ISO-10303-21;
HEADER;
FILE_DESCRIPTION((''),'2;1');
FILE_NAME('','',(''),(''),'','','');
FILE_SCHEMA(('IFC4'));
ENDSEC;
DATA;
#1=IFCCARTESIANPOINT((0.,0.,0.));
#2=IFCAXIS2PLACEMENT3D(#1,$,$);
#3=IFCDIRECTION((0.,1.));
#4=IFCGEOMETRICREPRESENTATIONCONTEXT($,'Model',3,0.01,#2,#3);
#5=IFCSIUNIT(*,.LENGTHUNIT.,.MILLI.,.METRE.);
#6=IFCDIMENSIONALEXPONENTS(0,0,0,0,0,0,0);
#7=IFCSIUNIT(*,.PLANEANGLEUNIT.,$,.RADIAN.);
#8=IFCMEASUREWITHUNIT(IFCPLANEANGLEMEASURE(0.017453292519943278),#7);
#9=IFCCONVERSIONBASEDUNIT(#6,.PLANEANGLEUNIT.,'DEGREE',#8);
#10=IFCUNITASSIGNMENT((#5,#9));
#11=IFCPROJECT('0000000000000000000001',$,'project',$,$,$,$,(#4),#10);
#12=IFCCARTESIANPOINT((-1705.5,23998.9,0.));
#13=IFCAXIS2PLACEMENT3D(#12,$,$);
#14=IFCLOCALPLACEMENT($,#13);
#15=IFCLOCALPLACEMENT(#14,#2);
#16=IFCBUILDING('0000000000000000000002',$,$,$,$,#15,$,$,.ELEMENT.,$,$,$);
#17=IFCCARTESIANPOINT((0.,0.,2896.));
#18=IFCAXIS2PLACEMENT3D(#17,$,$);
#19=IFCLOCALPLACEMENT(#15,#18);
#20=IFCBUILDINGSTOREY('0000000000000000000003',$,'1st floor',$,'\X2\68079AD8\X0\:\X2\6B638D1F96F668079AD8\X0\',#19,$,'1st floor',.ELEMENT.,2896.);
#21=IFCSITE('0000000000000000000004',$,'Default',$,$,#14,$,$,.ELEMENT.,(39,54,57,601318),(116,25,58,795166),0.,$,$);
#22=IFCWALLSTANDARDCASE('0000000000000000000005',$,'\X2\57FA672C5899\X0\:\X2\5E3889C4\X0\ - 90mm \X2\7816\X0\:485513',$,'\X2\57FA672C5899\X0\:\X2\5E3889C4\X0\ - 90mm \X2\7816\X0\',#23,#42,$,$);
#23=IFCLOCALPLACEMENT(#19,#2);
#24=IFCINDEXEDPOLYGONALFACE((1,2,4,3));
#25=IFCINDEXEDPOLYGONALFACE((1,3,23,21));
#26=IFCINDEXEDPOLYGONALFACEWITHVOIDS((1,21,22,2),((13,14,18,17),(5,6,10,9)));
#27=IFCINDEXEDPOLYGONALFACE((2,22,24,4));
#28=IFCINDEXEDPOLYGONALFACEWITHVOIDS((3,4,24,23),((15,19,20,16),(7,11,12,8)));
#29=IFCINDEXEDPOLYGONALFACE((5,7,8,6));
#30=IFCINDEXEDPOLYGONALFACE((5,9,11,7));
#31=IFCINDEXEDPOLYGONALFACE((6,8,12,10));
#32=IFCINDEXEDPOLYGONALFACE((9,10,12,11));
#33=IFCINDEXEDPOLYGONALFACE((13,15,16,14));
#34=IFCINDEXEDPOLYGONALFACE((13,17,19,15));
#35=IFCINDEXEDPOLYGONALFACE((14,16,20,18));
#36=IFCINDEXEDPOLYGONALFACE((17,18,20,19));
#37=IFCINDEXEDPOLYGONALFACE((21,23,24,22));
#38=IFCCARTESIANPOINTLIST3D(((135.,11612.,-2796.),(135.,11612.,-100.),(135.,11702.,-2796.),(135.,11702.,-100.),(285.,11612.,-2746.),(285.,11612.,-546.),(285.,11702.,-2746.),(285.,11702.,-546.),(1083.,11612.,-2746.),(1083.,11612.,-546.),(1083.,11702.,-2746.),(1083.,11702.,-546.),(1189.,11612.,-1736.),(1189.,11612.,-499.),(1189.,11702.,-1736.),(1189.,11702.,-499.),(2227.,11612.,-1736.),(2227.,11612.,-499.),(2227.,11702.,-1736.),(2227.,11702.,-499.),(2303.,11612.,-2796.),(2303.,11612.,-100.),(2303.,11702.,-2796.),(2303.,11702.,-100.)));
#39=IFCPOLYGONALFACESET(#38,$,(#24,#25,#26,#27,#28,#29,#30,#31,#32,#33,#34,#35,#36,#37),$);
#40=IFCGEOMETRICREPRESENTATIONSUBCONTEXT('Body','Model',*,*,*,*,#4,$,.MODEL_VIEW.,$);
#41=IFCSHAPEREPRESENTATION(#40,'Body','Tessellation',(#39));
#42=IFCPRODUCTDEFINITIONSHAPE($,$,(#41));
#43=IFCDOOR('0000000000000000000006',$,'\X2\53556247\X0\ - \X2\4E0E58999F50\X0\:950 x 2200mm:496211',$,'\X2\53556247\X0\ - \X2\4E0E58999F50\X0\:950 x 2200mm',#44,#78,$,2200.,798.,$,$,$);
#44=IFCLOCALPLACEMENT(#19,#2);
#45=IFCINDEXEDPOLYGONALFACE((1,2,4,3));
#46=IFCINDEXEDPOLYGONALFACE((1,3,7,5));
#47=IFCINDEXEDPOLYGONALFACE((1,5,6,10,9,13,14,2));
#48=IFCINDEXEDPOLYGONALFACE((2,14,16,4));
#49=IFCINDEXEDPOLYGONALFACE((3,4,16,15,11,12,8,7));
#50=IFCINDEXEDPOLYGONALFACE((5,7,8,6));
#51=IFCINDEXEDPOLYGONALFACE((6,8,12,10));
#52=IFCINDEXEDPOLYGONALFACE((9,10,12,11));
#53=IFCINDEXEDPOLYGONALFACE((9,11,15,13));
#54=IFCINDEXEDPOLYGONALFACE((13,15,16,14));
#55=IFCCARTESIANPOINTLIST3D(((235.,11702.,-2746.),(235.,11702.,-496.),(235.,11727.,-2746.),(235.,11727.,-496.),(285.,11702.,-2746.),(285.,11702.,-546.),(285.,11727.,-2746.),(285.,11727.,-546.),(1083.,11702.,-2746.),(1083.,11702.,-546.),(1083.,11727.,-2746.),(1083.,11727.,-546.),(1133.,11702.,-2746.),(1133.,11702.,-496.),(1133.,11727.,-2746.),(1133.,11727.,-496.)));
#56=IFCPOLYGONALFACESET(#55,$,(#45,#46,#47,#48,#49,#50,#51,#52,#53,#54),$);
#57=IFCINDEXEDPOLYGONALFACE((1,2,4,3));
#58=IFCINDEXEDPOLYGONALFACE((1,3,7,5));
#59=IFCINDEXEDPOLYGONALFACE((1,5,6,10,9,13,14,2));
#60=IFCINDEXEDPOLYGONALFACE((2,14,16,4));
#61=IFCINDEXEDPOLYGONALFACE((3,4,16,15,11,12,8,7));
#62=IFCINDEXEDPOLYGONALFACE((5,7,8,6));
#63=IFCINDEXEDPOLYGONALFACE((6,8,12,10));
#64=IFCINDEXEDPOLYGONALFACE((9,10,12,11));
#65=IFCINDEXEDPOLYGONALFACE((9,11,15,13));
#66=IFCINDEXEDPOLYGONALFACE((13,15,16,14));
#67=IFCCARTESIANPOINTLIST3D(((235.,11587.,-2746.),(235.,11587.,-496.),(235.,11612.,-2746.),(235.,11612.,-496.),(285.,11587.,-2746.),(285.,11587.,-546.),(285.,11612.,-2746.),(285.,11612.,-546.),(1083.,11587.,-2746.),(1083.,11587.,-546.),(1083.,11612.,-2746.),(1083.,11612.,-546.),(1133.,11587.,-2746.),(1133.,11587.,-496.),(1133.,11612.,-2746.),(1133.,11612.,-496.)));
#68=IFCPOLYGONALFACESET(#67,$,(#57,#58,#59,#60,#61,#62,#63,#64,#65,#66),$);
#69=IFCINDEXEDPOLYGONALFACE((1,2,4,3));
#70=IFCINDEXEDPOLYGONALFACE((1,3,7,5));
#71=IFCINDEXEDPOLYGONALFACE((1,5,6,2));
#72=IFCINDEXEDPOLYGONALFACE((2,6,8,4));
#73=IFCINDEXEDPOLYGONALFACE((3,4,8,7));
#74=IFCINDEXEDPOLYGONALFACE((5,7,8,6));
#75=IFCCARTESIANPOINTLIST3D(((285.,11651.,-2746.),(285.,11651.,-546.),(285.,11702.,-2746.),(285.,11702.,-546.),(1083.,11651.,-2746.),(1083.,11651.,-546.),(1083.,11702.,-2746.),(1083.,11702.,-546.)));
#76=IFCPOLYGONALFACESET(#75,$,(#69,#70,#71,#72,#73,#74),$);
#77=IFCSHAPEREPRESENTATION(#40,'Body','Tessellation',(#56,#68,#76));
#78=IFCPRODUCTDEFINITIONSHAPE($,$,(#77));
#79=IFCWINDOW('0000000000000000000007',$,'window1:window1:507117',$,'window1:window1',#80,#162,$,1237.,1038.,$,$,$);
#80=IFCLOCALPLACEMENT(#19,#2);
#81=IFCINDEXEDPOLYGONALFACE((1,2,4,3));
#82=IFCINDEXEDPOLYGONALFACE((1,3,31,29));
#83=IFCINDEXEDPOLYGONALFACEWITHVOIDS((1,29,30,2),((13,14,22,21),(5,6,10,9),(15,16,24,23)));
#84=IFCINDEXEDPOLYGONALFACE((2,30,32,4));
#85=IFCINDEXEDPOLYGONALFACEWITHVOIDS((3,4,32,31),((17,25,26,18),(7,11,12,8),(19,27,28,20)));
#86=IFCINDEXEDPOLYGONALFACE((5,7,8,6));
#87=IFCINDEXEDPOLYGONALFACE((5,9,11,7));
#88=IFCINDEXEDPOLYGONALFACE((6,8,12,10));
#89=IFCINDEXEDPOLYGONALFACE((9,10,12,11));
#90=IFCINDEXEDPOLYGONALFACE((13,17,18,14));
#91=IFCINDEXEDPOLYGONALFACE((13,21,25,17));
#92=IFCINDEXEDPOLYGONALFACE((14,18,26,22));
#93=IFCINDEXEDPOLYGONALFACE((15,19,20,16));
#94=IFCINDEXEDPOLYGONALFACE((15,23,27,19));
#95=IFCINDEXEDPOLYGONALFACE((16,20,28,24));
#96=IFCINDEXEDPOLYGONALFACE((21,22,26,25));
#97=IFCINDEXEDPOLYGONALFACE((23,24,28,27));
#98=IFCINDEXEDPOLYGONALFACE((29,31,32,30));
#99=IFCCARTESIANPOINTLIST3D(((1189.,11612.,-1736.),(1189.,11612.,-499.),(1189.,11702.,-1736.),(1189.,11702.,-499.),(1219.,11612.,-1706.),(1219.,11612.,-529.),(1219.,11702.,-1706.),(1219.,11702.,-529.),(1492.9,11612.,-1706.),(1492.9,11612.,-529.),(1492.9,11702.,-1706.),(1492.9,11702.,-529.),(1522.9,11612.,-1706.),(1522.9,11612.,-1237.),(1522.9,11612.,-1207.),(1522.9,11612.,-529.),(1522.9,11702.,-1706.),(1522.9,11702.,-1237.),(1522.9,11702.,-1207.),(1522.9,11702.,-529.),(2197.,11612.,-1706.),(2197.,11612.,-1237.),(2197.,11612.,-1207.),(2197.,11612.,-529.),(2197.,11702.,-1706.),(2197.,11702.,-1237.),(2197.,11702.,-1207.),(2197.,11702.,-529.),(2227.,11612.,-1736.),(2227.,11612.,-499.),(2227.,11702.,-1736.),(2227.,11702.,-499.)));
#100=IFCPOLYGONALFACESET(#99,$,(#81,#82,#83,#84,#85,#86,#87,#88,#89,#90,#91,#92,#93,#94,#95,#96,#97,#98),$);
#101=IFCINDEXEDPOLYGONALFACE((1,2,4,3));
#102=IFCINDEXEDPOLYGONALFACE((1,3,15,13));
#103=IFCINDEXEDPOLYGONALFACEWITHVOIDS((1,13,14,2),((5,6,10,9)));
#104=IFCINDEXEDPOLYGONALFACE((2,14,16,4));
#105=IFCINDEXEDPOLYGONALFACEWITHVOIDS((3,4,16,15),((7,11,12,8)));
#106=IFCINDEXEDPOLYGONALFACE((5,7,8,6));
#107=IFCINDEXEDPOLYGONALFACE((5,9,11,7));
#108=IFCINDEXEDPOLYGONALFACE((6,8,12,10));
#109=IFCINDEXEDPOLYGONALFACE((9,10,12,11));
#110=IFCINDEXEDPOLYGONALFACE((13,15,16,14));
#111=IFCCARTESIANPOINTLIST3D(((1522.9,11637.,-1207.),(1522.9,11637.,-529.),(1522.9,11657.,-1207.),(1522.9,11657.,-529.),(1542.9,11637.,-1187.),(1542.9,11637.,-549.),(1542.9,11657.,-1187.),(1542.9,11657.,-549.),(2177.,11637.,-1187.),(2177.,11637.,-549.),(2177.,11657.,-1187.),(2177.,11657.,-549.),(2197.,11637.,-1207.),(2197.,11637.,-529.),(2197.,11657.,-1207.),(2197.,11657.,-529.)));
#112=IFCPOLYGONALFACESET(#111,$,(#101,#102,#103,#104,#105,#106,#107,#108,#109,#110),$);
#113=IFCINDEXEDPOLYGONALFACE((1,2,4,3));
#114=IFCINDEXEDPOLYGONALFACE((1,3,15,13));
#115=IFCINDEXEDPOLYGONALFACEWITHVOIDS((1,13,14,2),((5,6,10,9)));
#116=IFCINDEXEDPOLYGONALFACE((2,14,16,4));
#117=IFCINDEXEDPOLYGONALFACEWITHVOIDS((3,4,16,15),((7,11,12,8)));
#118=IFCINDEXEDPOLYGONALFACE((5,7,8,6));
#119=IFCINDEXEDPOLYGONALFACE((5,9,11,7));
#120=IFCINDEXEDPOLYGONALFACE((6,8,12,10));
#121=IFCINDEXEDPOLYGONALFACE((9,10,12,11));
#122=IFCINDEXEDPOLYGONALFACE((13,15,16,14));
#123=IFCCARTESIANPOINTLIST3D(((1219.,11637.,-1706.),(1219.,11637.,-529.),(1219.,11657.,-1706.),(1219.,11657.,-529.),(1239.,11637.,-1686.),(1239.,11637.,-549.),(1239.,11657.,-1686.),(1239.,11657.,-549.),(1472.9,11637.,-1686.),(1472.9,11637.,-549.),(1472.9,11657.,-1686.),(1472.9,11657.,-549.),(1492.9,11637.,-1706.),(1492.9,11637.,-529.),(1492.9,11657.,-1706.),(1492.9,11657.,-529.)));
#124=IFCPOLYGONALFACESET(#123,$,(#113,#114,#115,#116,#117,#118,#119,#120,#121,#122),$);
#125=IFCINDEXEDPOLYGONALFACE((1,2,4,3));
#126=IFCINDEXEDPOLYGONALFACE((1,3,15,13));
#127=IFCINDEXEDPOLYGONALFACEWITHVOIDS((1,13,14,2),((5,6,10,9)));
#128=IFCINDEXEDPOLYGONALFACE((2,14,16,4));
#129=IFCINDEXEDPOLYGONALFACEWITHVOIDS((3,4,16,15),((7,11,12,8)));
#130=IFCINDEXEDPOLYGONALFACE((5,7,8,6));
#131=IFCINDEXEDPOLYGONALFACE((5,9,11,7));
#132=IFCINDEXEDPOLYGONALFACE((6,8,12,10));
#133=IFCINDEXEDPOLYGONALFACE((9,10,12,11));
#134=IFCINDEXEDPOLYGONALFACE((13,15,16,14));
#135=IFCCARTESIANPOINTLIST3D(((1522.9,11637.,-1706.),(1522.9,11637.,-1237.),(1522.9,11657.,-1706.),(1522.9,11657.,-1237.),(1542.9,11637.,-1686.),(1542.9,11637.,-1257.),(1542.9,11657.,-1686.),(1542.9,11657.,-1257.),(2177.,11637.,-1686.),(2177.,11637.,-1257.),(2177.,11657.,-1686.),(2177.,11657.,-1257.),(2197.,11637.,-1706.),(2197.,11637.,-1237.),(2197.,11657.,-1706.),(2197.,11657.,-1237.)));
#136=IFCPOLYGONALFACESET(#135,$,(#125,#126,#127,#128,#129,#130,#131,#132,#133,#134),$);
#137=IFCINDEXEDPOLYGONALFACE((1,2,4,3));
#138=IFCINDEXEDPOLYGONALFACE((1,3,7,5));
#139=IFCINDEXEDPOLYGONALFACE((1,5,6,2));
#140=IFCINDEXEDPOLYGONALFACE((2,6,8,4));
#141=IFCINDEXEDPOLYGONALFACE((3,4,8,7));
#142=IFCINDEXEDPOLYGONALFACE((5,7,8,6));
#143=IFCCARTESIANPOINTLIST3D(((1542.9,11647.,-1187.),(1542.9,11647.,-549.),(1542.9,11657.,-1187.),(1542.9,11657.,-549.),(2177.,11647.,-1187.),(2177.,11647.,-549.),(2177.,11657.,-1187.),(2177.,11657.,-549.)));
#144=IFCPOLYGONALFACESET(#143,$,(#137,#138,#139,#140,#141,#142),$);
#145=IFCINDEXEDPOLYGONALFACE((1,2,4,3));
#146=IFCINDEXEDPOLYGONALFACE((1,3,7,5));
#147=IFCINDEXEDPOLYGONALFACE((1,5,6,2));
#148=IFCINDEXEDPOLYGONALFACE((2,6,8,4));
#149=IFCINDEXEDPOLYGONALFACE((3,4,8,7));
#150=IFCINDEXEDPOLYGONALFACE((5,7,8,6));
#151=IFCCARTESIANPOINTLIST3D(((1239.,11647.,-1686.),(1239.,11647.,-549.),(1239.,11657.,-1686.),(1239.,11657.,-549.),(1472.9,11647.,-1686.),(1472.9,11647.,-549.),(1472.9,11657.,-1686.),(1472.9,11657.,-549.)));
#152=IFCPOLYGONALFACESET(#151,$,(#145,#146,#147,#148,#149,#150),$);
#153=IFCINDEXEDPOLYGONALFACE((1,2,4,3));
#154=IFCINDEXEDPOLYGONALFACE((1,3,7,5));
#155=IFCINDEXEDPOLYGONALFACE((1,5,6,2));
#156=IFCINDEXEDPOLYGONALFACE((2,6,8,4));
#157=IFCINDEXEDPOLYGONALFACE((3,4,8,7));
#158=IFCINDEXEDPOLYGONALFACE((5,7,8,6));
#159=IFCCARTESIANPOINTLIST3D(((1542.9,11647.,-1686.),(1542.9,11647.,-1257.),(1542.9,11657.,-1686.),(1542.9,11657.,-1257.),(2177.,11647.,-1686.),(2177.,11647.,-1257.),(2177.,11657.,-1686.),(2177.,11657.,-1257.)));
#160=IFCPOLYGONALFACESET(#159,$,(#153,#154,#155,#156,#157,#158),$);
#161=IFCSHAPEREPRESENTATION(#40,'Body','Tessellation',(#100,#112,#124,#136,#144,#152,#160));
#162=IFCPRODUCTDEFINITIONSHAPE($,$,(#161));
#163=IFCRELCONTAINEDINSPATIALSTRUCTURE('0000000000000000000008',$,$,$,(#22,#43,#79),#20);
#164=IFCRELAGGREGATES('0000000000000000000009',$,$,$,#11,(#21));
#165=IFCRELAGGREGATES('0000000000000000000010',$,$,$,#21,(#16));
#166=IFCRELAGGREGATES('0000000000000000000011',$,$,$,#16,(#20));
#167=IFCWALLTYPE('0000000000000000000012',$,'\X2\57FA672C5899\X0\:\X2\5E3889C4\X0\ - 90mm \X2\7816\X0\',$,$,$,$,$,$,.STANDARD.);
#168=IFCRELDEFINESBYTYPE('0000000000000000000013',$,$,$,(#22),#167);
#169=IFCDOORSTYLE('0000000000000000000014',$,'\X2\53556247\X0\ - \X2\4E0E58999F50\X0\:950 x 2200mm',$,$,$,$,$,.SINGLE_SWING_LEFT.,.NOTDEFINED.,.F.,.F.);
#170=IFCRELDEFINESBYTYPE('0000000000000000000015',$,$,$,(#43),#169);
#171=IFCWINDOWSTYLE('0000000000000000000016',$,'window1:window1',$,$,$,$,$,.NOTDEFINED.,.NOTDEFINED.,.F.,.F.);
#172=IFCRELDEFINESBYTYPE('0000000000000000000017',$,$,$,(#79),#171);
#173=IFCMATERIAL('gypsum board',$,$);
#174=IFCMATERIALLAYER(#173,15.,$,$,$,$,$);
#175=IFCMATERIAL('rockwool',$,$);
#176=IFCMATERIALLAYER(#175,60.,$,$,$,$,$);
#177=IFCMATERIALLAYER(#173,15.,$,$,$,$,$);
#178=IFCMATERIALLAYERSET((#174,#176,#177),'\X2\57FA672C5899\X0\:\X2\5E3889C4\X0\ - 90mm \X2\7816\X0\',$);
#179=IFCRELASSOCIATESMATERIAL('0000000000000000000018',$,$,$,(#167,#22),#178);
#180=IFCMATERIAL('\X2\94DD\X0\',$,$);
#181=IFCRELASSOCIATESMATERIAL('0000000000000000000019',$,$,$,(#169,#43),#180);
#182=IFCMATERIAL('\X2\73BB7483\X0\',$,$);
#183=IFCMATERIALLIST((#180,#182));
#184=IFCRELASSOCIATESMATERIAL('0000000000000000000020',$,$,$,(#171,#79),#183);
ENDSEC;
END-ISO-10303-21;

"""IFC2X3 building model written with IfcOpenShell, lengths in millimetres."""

from ifc_helpers import new_model, entity, si_unit, converted_unit, direction, frame, frame_2d, origin, origin_2d_with_axis, place, context, subcontext, project, spatial, polyline, rectangle, outline, extrude, source, transform, mapped, material, material_list, layer, layer_set, layer_usage, type_object, type_shapes, element, fill, save


model = new_model("IFC2X3")

# Units and contexts
model_context = context("Model", 3, precision=0.01, world=origin(), true_north=direction((0.0, 1.0)))
body_context = subcontext(model_context, "Body", "Model", "MODEL_VIEW")
ifc_project = project(units=[si_unit("LENGTHUNIT", "METRE", prefix="MILLI"), converted_unit("PLANEANGLEUNIT", "DEGREE", entity("IfcPlaneAngleMeasure", 0.017453292519943278), si_unit("PLANEANGLEUNIT", "RADIAN"), dimensions=[0, 0, 0, 0, 0, 0, 0])], contexts=[model_context])

# Site, building, storey
site_placement = place(None, frame((-1705.5, 23998.9, 0.0)))
site = spatial("IfcSite", under=ifc_project, at=site_placement, Name="Default", CompositionType="ELEMENT", RefLatitude=(39, 54, 57, 601318), RefLongitude=(116, 25, 58, 795166), RefElevation=0.0)
building_placement = place(site_placement, origin())
building = spatial("IfcBuilding", under=site, at=building_placement, CompositionType="ELEMENT")
storey_placement = place(building_placement, frame((0.0, 0.0, 2896.0)))
storey = spatial("IfcBuildingStorey", under=building, at=storey_placement, Name="1st floor", ObjectType="标高:正负零标高", LongName="1st floor", CompositionType="ELEMENT", Elevation=2896.0)

# Wall, openings, door, window
ifc_material_1 = material(Name="gypsum board")
ifc_layer_1 = layer(ifc_material_1, 15.0)
ifc_material_2 = material(Name="rockwool")
ifc_layer_2 = layer(ifc_material_2, 60.0)
ifc_layer_3 = layer(ifc_material_1, 15.0)
ifc_layer_set = layer_set([ifc_layer_1, ifc_layer_2, ifc_layer_3], Name="基本墙:常规 - 90mm 砖")
ifc_layer_usage_1 = layer_usage(ifc_layer_set, "AXIS2", "NEGATIVE", 45.0)
wall_type = type_object("IfcWallType", Name="基本墙:常规 - 90mm 砖", PredefinedType="STANDARD", material=ifc_layer_set)
wall_1_placement = place(storey_placement, frame((2303.0, 11657.0, -2796.0), z_axis=(0.0, 0.0, 1.0), x_axis=(-1.0, 0.0, 0.0)))
wall_1 = element("IfcWallStandardCase", 1, at=wall_1_placement, inside=storey, type_object=wall_type, material=ifc_layer_usage_1, Name="基本墙:常规 - 90mm 砖:485513", ObjectType="基本墙:常规 - 90mm 砖", context=body_context, shape_type="SweptSolid", body=[
    extrude(rectangle(XDim=2168.0, YDim=90.0, at=frame_2d((1084.0, 0.0), x_axis=(-1.0, 0.0))), origin(), (0.0, 0.0, 1.0), 2696.0),
])
opening_1_placement = place(wall_1_placement, frame((2018.0, 45.0, 50.0)))
opening_1 = element("IfcOpeningElement", 2, at=opening_1_placement, cuts=wall_1, ObjectType="Opening", context=body_context, shape_type="SweptSolid", body=[
    extrude(rectangle(XDim=798.0, YDim=2200.0, at=frame_2d((1100.0, 399.0), x_axis=(0.0, -1.0))), frame((0.0, 0.0, 0.0), z_axis=(0.0, -1.0, 0.0), x_axis=(0.0, 0.0, 1.0)), (0.0, 0.0, 1.0), 90.0),
])
opening_2_placement = place(wall_1_placement, frame((1114.0, 45.0, 1060.0)))
opening_2 = element("IfcOpeningElement", 3, at=opening_2_placement, cuts=wall_1, ObjectType="Opening", context=body_context, shape_type="SweptSolid", body=[
    extrude(rectangle(XDim=1237.0, YDim=1038.0, at=frame_2d((618.5, 519.0), x_axis=(1.0, 0.0))), frame((0.0, 0.0, 0.0), z_axis=(0.0, -1.0, 0.0), x_axis=(0.0, 0.0, 1.0)), (0.0, 0.0, 1.0), 90.0),
])
ifc_material_3 = material(Name="铝")
door_style = type_object("IfcDoorStyle", Name="单扇 - 与墙齐:950 x 2200mm", ConstructionType="NOTDEFINED", OperationType="SINGLE_SWING_LEFT", ParameterTakesPrecedence=False, Sizeable=False, material=ifc_material_3)
shared_shape_1 = source(origin(), body_context, "Body", "SweptSolid", [
    extrude(outline(polyline([(-449.0, -1137.5), (449.0, -1137.5), (449.0, 1112.5), (399.0, 1112.5), (399.0, -1087.5), (-399.0, -1087.5), (-399.0, 1112.5), (-449.0, 1112.5), (-449.0, -1137.5)])), frame((399.0, 115.0, 1112.5), z_axis=(0.0, -1.0, 0.0), x_axis=(-1.0, 0.0, 0.0)), (0.0, 0.0, 1.0), 25.0),
    extrude(outline(polyline([(-1137.5, -449.0), (1112.5, -449.0), (1112.5, -399.0), (-1087.5, -399.0), (-1087.5, 399.0), (1112.5, 399.0), (1112.5, 449.0), (-1137.5, 449.0), (-1137.5, -449.0)])), frame((399.0, 0.0, 1112.5), z_axis=(0.0, -1.0, 0.0), x_axis=(0.0, 0.0, -1.0)), (0.0, 0.0, 1.0), 25.0),
    extrude(rectangle(XDim=798.0, YDim=51.0, at=origin_2d_with_axis()), frame((399.0, 64.5, 0.0)), (0.0, 0.0, 1.0), 2200.0),
])
type_shapes(door_style, [shared_shape_1])
door_placement = place(opening_1_placement, frame((0.0, 0.0, 0.0), z_axis=(0.0, 0.0, 1.0), x_axis=(-1.0, 0.0, 0.0)))
door = element("IfcDoor", 4, at=door_placement, inside=storey, type_object=door_style, material=ifc_material_3, Name="单扇 - 与墙齐:950 x 2200mm:496211", ObjectType="单扇 - 与墙齐:950 x 2200mm", OverallHeight=2200.0, OverallWidth=798.0, context=body_context, shape_type="MappedRepresentation", body=[
    mapped(shared_shape_1, transform((0.0, 0.0, 0.0), scale=1.0)),
])
fill(opening_1, door)
ifc_material_4 = material(Name="玻璃")
ifc_material_list = material_list([ifc_material_3, ifc_material_4])
window_style = type_object("IfcWindowStyle", Name="window1:window1", ConstructionType="NOTDEFINED", OperationType="NOTDEFINED", ParameterTakesPrecedence=False, Sizeable=False, material=ifc_material_list)
shared_shape_2 = source(origin(), body_context, "Body", "SweptSolid", [
    extrude(outline(polyline([(-618.5, -519.0), (618.5, -519.0), (618.5, 519.0), (-618.5, 519.0), (-618.5, -519.0)]), holes=[polyline([(-588.5, -215.1), (588.5, -215.1), (588.5, -489.0), (-588.5, -489.0), (-588.5, -215.1)]), polyline([(89.5, -185.1), (-588.5, -185.1), (-588.5, 489.0), (89.5, 489.0), (89.5, -185.1)]), polyline([(119.5, 489.0), (588.5, 489.0), (588.5, -185.1), (119.5, -185.1), (119.5, 489.0)])]), frame((519.0, 90.0, 618.5), z_axis=(0.0, -1.0, 0.0), x_axis=(0.0, 0.0, -1.0)), (0.0, 0.0, 1.0), 90.0),
    extrude(outline(polyline([(-337.0, -339.0), (337.0, -339.0), (337.0, 339.0), (-337.0, 339.0), (-337.0, -339.0)]), holes=[polyline([(-317.0, -319.0), (-317.0, 319.0), (317.0, 319.0), (317.0, -319.0), (-317.0, -319.0)])]), frame((671.0, 45.0, 868.0), z_axis=(0.0, -1.0, 0.0), x_axis=(-1.0, 0.0, 0.0)), (0.0, 0.0, 1.0), 20.0),
    extrude(outline(polyline([(-137.0, -588.5), (137.0, -588.5), (137.0, 588.5), (-137.0, 588.5), (-137.0, -588.5)]), holes=[polyline([(-117.0, -568.5), (-117.0, 568.5), (117.0, 568.5), (117.0, -568.5), (-117.0, -568.5)])]), frame((167.0, 45.0, 618.5), z_axis=(0.0, -1.0, 0.0), x_axis=(-1.0, 0.0, 0.0)), (0.0, 0.0, 1.0), 20.0),
    extrude(outline(polyline([(-337.0, -234.5), (337.0, -234.5), (337.0, 234.5), (-337.0, 234.5), (-337.0, -234.5)]), holes=[polyline([(-317.0, -214.5), (-317.0, 214.5), (317.0, 214.5), (317.0, -214.5), (-317.0, -214.5)])]), frame((671.0, 45.0, 264.5), z_axis=(0.0, -1.0, 0.0), x_axis=(-1.0, 0.0, 0.0)), (0.0, 0.0, 1.0), 20.0),
    extrude(rectangle(XDim=634.1, YDim=10.0, at=frame_2d((0.0, 0.0), x_axis=(1.0, 0.0))), frame((671.0, 40.0, 549.0)), (0.0, 0.0, 1.0), 638.0),
    extrude(rectangle(XDim=233.9, YDim=10.0, at=frame_2d((0.0, 0.0), x_axis=(1.0, 0.0))), frame((167.0, 40.0, 50.0)), (0.0, 0.0, 1.0), 1137.0),
    extrude(rectangle(XDim=634.1, YDim=10.0, at=frame_2d((0.0, 0.0), x_axis=(1.0, 0.0))), frame((671.0, 40.0, 50.0)), (0.0, 0.0, 1.0), 429.0),
])
type_shapes(window_style, [shared_shape_2])
window_placement = place(opening_2_placement, frame((0.0, 0.0, 0.0), z_axis=(0.0, 0.0, 1.0), x_axis=(-1.0, 0.0, 0.0)))
window = element("IfcWindow", 5, at=window_placement, inside=storey, type_object=window_style, material=ifc_material_list, Name="window1:window1:507117", ObjectType="window1:window1", OverallHeight=1237.0, OverallWidth=1038.0, context=body_context, shape_type="MappedRepresentation", body=[
    mapped(shared_shape_2, transform((0.0, 0.0, 0.0), scale=1.0)),
])
fill(opening_2, window)

save(model, "model.ifc")
